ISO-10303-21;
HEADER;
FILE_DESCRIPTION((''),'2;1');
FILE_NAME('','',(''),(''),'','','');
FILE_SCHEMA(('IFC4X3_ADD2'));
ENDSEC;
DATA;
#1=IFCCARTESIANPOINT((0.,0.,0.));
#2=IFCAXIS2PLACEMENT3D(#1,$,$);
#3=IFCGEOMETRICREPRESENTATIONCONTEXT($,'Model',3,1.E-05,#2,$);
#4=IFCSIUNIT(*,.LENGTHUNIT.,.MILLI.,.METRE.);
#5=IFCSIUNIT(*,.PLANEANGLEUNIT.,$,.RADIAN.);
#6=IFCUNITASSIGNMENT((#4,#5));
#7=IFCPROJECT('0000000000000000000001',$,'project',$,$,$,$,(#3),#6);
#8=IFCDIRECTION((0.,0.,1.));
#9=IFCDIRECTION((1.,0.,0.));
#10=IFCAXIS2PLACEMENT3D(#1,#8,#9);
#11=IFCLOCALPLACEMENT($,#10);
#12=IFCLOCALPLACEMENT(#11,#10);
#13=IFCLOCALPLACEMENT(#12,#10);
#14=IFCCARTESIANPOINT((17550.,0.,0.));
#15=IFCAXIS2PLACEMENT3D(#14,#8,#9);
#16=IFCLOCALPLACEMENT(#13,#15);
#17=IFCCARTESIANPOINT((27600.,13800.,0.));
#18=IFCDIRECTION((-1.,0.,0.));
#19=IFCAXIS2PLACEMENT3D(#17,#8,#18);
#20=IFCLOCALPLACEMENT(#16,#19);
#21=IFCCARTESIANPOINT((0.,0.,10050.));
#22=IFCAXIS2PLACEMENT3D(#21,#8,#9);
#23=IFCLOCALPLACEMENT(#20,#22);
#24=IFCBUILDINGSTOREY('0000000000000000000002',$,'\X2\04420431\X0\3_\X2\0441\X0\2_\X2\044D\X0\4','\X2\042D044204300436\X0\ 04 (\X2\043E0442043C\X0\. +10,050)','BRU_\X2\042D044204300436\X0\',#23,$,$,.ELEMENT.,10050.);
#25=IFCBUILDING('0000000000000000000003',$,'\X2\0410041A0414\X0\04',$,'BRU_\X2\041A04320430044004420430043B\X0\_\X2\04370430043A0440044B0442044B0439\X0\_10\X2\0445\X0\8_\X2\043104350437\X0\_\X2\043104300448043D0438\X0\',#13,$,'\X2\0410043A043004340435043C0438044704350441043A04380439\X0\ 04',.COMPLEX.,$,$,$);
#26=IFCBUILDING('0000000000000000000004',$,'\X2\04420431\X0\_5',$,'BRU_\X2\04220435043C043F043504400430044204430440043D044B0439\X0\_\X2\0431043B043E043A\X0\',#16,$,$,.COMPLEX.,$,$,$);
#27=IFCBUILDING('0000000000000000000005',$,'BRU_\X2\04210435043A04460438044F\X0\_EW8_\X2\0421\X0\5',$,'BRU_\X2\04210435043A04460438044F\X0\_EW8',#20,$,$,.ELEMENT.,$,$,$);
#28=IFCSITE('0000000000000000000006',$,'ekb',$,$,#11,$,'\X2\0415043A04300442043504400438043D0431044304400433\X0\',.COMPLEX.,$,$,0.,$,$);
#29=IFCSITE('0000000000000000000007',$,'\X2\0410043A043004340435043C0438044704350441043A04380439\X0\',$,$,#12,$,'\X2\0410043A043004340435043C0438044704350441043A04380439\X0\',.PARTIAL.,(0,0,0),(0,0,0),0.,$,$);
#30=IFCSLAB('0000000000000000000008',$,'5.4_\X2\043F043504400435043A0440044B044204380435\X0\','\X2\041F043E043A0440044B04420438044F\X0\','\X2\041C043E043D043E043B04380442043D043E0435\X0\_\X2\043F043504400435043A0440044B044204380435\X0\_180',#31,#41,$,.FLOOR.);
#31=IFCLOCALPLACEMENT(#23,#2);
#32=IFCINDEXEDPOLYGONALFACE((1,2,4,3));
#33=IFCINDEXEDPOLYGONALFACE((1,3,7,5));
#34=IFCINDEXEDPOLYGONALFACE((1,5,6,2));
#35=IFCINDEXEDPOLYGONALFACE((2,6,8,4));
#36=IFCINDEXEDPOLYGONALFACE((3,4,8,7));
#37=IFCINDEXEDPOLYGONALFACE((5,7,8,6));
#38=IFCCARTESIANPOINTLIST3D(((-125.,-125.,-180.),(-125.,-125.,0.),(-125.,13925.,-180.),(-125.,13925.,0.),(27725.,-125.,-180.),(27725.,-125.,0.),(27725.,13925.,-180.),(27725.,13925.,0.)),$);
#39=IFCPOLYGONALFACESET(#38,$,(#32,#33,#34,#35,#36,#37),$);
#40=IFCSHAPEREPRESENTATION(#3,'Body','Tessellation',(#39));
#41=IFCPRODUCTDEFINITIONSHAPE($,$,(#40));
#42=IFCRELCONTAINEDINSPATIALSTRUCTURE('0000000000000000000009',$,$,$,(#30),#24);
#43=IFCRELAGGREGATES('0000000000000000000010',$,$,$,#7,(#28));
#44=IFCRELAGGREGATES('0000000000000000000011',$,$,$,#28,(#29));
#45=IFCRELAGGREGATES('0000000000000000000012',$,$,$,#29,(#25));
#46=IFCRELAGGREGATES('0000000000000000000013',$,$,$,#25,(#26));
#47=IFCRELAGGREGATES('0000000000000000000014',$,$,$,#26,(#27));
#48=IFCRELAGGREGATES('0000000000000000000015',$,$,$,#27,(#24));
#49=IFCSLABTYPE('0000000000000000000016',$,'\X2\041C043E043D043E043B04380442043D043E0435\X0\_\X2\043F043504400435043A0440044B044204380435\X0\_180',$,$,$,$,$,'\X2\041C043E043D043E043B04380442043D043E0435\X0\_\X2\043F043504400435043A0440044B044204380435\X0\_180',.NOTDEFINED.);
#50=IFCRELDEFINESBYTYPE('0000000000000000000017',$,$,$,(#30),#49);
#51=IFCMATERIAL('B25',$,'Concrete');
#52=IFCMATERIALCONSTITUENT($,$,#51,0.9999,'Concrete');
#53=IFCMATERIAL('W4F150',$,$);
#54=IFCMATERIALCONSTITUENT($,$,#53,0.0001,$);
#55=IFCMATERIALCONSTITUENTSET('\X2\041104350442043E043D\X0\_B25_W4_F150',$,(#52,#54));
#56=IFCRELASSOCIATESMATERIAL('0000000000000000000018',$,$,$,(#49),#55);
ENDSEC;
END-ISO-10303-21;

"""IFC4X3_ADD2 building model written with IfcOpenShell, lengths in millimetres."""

from ifc_helpers import new_model, si_unit, frame, origin, origin_with_axes, place, context, project, spatial, polyline, outline, extrude, material, constituent, constituent_set, type_object, element, save


model = new_model("IFC4X3_ADD2")

# Units and contexts
model_context = context("Model", 3, precision=1e-05, world=origin())
ifc_project = project(units=[si_unit("LENGTHUNIT", "METRE", prefix="MILLI"), si_unit("PLANEANGLEUNIT", "RADIAN")], contexts=[model_context])

# Sites, buildings, storey
site_1_placement = place(None, origin_with_axes())
site_1 = spatial("IfcSite", under=ifc_project, at=site_1_placement, Name="ekb", LongName="Екатеринбург", CompositionType="COMPLEX", RefElevation=0.0)
site_2_placement = place(site_1_placement, origin_with_axes())
site_2 = spatial("IfcSite", under=site_1, at=site_2_placement, Name="Академический", LongName="Академический", CompositionType="PARTIAL", RefLatitude=(0, 0, 0), RefLongitude=(0, 0, 0), RefElevation=0.0)
building_1_placement = place(site_2_placement, origin_with_axes())
building_1 = spatial("IfcBuilding", under=site_2, at=building_1_placement, Name="АКД04", ObjectType="BRU_Квартал_закрытый_10х8_без_башни", LongName="Академический 04", CompositionType="COMPLEX")
building_2_placement = place(building_1_placement, frame((17550.0, 0.0, 0.0), z_axis=(0.0, 0.0, 1.0), x_axis=(1.0, 0.0, 0.0)))
building_2 = spatial("IfcBuilding", under=building_1, at=building_2_placement, Name="тб_5", ObjectType="BRU_Температурный_блок", CompositionType="COMPLEX")
building_3_placement = place(building_2_placement, frame((27600.0, 13800.0, 0.0), z_axis=(0.0, 0.0, 1.0), x_axis=(-1.0, 0.0, 0.0)))
building_3 = spatial("IfcBuilding", under=building_2, at=building_3_placement, Name="BRU_Секция_EW8_С5", ObjectType="BRU_Секция_EW8", CompositionType="ELEMENT")
storey_placement = place(building_3_placement, frame((0.0, 0.0, 10050.0), z_axis=(0.0, 0.0, 1.0), x_axis=(1.0, 0.0, 0.0)))
storey = spatial("IfcBuildingStorey", under=building_3, at=storey_placement, Name="тб3_с2_э4", Description="Этаж 04 (отм. +10,050)", ObjectType="BRU_Этаж", CompositionType="ELEMENT", Elevation=10050.0)

# Shared definitions
ifc_material_1 = material(Name="B25", Category="Concrete")
ifc_material_2 = material(Name="W4F150")

# Slab
ifc_constituent_1 = constituent(ifc_material_1, Category="Concrete", fraction=0.9999)
ifc_constituent_2 = constituent(ifc_material_2, fraction=0.0001)
ifc_constituent_set_1 = constituent_set(constituents=[ifc_constituent_1, ifc_constituent_2], Name="Бетон_B25_W4_F150")
slab_type = type_object("IfcSlabType", Name="Монолитное_перекрытие_180", ElementType="Монолитное_перекрытие_180", PredefinedType="NOTDEFINED", material=ifc_constituent_set_1)
slab_placement = place(storey_placement, frame((0.0, 0.0, -180.0), z_axis=(0.0, 0.0, 1.0), x_axis=(1.0, 0.0, 0.0)))
element("IfcSlab", 1, at=slab_placement, inside=storey, type_object=slab_type, Name="5.4_перекрытие", Description="Покрытия", ObjectType="Монолитное_перекрытие_180", PredefinedType="FLOOR", context=model_context, shape_type="SweptSolid", body=[
    extrude(outline(polyline([(27725.0, 13925.0), (-125.0, 13925.0), (-125.0, -125.0), (27725.0, -125.0), (27725.0, 13925.0)])), origin_with_axes(), (0.0, 0.0, 1.0), 180.0),
])

save(model, "model.ifc")
